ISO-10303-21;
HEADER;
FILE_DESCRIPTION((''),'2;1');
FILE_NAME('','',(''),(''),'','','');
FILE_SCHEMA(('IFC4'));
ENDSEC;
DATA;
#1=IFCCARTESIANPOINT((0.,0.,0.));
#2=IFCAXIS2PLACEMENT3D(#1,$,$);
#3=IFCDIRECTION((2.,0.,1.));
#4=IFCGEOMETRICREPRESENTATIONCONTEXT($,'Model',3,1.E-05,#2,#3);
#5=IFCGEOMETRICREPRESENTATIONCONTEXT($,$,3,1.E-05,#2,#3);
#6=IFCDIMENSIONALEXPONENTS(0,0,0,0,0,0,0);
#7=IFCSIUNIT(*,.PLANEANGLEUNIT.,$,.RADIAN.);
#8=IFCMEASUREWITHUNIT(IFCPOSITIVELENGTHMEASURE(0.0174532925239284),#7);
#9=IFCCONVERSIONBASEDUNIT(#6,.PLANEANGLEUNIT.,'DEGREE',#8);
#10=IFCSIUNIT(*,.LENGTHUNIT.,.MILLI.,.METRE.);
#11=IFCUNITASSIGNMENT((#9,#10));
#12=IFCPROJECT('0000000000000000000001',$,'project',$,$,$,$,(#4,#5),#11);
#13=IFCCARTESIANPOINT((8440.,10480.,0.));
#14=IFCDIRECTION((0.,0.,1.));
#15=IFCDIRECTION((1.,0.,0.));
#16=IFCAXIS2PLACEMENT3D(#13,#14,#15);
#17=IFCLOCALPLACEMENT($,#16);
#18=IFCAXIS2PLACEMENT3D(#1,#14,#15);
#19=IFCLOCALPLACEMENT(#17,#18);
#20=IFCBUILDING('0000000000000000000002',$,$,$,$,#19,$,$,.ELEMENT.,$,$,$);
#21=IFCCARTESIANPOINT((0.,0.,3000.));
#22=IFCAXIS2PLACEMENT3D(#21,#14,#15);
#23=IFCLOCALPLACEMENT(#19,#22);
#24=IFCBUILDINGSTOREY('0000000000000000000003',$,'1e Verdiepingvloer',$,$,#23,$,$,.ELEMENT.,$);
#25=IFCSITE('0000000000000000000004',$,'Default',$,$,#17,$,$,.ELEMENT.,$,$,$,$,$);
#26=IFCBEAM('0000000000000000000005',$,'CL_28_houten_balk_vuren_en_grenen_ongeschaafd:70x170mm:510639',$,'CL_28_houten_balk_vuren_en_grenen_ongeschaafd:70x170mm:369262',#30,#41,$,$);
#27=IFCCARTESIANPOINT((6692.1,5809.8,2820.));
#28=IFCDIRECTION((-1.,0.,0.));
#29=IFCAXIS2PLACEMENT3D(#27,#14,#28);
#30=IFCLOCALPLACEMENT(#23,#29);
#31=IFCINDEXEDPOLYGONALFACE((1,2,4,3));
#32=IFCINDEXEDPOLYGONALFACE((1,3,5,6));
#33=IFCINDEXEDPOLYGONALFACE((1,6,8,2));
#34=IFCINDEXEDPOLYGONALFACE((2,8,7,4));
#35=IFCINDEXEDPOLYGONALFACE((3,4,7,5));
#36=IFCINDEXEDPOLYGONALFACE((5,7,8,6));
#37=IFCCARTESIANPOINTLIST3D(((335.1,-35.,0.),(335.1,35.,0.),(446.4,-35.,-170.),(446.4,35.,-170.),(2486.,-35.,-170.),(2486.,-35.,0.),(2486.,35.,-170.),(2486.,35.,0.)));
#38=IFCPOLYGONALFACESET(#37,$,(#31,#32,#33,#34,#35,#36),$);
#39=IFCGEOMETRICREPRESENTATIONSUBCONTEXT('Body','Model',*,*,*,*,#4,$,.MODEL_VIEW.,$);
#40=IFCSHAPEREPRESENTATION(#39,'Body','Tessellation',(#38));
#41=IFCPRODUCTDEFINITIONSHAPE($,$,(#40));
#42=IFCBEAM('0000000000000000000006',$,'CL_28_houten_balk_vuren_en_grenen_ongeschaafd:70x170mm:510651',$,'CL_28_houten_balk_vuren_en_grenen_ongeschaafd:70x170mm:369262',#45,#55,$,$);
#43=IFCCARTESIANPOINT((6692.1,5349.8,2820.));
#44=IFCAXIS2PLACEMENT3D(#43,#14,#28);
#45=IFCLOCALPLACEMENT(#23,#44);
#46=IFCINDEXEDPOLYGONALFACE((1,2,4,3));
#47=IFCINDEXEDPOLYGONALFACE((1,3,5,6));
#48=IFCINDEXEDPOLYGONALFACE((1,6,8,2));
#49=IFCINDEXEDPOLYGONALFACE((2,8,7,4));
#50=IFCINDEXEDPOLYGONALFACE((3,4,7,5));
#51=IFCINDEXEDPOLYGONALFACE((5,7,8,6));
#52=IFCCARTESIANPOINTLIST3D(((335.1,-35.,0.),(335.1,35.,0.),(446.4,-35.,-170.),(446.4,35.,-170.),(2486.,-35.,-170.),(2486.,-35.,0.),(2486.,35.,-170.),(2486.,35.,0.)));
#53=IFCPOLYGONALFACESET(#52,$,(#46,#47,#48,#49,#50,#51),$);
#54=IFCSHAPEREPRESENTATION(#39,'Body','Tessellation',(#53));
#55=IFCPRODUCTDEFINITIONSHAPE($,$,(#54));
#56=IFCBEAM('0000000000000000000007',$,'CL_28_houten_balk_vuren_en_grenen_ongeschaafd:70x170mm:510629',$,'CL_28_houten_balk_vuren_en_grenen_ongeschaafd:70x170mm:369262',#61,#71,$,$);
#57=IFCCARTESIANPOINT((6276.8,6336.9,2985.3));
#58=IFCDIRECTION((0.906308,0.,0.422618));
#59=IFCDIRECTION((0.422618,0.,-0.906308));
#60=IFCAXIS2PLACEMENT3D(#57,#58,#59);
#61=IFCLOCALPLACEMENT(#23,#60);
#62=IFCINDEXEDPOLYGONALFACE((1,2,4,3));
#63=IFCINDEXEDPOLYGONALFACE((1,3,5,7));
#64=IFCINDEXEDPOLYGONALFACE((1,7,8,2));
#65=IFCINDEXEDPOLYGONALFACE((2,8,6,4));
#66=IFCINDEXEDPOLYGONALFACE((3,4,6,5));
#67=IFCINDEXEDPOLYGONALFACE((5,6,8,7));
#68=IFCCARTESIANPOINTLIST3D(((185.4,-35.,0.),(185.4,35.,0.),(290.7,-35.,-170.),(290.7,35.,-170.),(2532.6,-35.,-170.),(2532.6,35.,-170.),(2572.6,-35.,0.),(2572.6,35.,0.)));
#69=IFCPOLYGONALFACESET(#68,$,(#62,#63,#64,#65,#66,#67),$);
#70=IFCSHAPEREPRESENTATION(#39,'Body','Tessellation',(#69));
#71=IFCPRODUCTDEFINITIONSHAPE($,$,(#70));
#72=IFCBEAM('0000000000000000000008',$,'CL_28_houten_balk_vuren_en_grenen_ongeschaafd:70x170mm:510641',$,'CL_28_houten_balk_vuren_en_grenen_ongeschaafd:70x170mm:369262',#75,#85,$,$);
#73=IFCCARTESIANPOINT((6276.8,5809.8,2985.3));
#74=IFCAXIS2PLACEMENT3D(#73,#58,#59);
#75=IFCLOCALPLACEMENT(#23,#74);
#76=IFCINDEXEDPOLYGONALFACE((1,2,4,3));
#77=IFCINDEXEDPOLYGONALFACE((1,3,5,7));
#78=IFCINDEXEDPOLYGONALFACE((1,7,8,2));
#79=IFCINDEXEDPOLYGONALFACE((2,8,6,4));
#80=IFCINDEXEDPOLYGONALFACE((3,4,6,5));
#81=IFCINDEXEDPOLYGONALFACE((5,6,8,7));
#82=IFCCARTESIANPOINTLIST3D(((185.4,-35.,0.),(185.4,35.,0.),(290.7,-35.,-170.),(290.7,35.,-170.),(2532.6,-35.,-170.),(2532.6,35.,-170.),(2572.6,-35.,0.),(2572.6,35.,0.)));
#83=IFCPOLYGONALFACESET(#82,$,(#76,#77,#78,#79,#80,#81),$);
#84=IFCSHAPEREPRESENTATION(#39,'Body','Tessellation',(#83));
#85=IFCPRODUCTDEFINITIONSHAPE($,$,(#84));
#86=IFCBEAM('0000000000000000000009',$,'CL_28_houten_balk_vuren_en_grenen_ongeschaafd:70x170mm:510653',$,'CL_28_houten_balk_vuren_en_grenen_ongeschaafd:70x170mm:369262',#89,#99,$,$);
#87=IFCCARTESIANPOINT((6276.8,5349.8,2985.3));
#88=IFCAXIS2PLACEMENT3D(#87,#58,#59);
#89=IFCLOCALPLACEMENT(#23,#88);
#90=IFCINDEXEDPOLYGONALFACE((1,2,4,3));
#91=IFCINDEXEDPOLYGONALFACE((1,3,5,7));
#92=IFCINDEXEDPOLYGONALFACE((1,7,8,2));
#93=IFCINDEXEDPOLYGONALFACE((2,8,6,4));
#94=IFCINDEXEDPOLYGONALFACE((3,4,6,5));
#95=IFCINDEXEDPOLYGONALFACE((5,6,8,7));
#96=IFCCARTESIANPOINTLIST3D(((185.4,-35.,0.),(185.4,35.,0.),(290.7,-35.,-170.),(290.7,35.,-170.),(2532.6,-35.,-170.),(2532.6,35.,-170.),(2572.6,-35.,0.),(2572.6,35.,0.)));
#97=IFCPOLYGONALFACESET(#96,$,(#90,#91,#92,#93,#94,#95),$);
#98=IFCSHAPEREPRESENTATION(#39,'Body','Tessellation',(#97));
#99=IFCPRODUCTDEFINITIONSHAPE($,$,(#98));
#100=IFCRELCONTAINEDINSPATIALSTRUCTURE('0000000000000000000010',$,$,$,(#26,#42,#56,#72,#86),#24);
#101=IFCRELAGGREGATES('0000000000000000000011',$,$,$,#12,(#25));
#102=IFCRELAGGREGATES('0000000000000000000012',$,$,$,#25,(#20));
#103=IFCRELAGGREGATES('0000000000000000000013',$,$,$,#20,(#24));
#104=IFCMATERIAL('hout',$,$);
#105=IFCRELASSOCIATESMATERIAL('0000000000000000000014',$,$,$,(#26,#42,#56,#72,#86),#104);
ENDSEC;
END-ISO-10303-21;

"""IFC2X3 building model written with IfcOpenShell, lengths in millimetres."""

from ifc_helpers import new_model, entity, si_unit, converted_unit, direction, frame, frame_2d, origin, origin_with_axes, place, context, subcontext, project, spatial, rectangle, extrude, clip, halfspace, source, transform, mapped, material, element, save


model = new_model("IFC2X3")

# Units and contexts
model_context = context("Model", 3, precision=1e-05, world=origin(), true_north=direction((2.0, 0.0, 1.0)))
context_of_model = context(None, 3, precision=1e-05, world=origin(), true_north=direction((2.0, 0.0, 1.0)))
body_context = subcontext(model_context, "Body", "Model", "MODEL_VIEW")
ifc_project = project(units=[converted_unit("PLANEANGLEUNIT", "DEGREE", entity("IfcPositiveLengthMeasure", 0.0174532925239284), si_unit("PLANEANGLEUNIT", "RADIAN"), dimensions=[0, 0, 0, 0, 0, 0, 0]), si_unit("LENGTHUNIT", "METRE", prefix="MILLI")], contexts=[model_context, context_of_model])

# Site, building, storey
site_placement = place(None, frame((8440.0, 10480.0, 0.0), z_axis=(0.0, 0.0, 1.0), x_axis=(1.0, 0.0, 0.0)))
site = spatial("IfcSite", under=ifc_project, at=site_placement, Name="Default", CompositionType="ELEMENT")
building_placement = place(site_placement, origin_with_axes())
building = spatial("IfcBuilding", under=site, at=building_placement, CompositionType="ELEMENT")
storey_placement = place(building_placement, frame((0.0, 0.0, 3000.0), z_axis=(0.0, 0.0, 1.0), x_axis=(1.0, 0.0, 0.0)))
storey = spatial("IfcBuildingStorey", under=building, at=storey_placement, Name="1e Verdiepingvloer", CompositionType="ELEMENT")

# Beams
ifc_material_1 = material(Name="hout")
shared_shape_1 = source(origin(), body_context, "Body", "Clipping", [
    clip(extrude(rectangle(XDim=170.0, YDim=70.0, at=frame_2d((0.0, 0.0), x_axis=(1.0, 0.0))), frame((335.1, 0.0, -85.0), z_axis=(1.0, 0.0, 0.0), x_axis=(0.0, 0.0, -1.0)), (0.0, 0.0, 1.0), 2150.9), halfspace(frame((446.4, 1070.7, -170.0), z_axis=(-0.836561, 0.0, -0.547874), x_axis=(-0.547874, 0.0, 0.836561)), False)),
])
for number, where, z_axis, x_axis, name in (
    (1, (6692.1, 5809.8, 2820.0), (0.0, 0.0, 1.0), (-1.0, 0.0, 0.0), "CL_28_houten_balk_vuren_en_grenen_ongeschaafd:70x170mm:510639"),
    (2, (6692.1, 5349.8, 2820.0), (0.0, 0.0, 1.0), (-1.0, 0.0, 0.0), "CL_28_houten_balk_vuren_en_grenen_ongeschaafd:70x170mm:510651"),
):
    element("IfcBeam", number, at=place(storey_placement, frame(where, z_axis=z_axis, x_axis=x_axis)), inside=storey, material=ifc_material_1, Name=name, ObjectType="CL_28_houten_balk_vuren_en_grenen_ongeschaafd:70x170mm:369262", context=body_context, shape_type="MappedRepresentation", body=[
        mapped(shared_shape_1, transform((0.0, 0.0, 0.0))),
    ])
shared_shape_2 = source(origin(), body_context, "Body", "Clipping", [
    clip(clip(extrude(rectangle(XDim=170.0, YDim=70.0, at=frame_2d((0.0, 0.0), x_axis=(1.0, 0.0))), frame((185.4, 0.0, -85.0), z_axis=(1.0, 0.0, 0.0), x_axis=(0.0, 0.0, -1.0)), (0.0, 0.0, 1.0), 2387.2), halfspace(frame((2532.6, -2690.7, -170.0), z_axis=(0.973348, 0.0, -0.229334), x_axis=(0.229334, 0.0, 0.973348)), False)), halfspace(frame((290.7, -2690.7, -170.0), z_axis=(-0.850088, 0.0, -0.52664), x_axis=(-0.52664, 0.0, 0.850088)), False)),
])
for number, where, z_axis, x_axis, name in (
    (3, (6276.8, 6336.9, 2985.3), (0.906308, 0.0, 0.422618), (0.422618, 0.0, -0.906308), "CL_28_houten_balk_vuren_en_grenen_ongeschaafd:70x170mm:510629"),
    (4, (6276.8, 5809.8, 2985.3), (0.906308, 0.0, 0.422618), (0.422618, 0.0, -0.906308), "CL_28_houten_balk_vuren_en_grenen_ongeschaafd:70x170mm:510641"),
    (5, (6276.8, 5349.8, 2985.3), (0.906308, 0.0, 0.422618), (0.422618, 0.0, -0.906308), "CL_28_houten_balk_vuren_en_grenen_ongeschaafd:70x170mm:510653"),
):
    element("IfcBeam", number, at=place(storey_placement, frame(where, z_axis=z_axis, x_axis=x_axis)), inside=storey, material=ifc_material_1, Name=name, ObjectType="CL_28_houten_balk_vuren_en_grenen_ongeschaafd:70x170mm:369262", context=body_context, shape_type="MappedRepresentation", body=[
        mapped(shared_shape_2, transform((0.0, 0.0, 0.0))),
    ])

save(model, "model.ifc")
